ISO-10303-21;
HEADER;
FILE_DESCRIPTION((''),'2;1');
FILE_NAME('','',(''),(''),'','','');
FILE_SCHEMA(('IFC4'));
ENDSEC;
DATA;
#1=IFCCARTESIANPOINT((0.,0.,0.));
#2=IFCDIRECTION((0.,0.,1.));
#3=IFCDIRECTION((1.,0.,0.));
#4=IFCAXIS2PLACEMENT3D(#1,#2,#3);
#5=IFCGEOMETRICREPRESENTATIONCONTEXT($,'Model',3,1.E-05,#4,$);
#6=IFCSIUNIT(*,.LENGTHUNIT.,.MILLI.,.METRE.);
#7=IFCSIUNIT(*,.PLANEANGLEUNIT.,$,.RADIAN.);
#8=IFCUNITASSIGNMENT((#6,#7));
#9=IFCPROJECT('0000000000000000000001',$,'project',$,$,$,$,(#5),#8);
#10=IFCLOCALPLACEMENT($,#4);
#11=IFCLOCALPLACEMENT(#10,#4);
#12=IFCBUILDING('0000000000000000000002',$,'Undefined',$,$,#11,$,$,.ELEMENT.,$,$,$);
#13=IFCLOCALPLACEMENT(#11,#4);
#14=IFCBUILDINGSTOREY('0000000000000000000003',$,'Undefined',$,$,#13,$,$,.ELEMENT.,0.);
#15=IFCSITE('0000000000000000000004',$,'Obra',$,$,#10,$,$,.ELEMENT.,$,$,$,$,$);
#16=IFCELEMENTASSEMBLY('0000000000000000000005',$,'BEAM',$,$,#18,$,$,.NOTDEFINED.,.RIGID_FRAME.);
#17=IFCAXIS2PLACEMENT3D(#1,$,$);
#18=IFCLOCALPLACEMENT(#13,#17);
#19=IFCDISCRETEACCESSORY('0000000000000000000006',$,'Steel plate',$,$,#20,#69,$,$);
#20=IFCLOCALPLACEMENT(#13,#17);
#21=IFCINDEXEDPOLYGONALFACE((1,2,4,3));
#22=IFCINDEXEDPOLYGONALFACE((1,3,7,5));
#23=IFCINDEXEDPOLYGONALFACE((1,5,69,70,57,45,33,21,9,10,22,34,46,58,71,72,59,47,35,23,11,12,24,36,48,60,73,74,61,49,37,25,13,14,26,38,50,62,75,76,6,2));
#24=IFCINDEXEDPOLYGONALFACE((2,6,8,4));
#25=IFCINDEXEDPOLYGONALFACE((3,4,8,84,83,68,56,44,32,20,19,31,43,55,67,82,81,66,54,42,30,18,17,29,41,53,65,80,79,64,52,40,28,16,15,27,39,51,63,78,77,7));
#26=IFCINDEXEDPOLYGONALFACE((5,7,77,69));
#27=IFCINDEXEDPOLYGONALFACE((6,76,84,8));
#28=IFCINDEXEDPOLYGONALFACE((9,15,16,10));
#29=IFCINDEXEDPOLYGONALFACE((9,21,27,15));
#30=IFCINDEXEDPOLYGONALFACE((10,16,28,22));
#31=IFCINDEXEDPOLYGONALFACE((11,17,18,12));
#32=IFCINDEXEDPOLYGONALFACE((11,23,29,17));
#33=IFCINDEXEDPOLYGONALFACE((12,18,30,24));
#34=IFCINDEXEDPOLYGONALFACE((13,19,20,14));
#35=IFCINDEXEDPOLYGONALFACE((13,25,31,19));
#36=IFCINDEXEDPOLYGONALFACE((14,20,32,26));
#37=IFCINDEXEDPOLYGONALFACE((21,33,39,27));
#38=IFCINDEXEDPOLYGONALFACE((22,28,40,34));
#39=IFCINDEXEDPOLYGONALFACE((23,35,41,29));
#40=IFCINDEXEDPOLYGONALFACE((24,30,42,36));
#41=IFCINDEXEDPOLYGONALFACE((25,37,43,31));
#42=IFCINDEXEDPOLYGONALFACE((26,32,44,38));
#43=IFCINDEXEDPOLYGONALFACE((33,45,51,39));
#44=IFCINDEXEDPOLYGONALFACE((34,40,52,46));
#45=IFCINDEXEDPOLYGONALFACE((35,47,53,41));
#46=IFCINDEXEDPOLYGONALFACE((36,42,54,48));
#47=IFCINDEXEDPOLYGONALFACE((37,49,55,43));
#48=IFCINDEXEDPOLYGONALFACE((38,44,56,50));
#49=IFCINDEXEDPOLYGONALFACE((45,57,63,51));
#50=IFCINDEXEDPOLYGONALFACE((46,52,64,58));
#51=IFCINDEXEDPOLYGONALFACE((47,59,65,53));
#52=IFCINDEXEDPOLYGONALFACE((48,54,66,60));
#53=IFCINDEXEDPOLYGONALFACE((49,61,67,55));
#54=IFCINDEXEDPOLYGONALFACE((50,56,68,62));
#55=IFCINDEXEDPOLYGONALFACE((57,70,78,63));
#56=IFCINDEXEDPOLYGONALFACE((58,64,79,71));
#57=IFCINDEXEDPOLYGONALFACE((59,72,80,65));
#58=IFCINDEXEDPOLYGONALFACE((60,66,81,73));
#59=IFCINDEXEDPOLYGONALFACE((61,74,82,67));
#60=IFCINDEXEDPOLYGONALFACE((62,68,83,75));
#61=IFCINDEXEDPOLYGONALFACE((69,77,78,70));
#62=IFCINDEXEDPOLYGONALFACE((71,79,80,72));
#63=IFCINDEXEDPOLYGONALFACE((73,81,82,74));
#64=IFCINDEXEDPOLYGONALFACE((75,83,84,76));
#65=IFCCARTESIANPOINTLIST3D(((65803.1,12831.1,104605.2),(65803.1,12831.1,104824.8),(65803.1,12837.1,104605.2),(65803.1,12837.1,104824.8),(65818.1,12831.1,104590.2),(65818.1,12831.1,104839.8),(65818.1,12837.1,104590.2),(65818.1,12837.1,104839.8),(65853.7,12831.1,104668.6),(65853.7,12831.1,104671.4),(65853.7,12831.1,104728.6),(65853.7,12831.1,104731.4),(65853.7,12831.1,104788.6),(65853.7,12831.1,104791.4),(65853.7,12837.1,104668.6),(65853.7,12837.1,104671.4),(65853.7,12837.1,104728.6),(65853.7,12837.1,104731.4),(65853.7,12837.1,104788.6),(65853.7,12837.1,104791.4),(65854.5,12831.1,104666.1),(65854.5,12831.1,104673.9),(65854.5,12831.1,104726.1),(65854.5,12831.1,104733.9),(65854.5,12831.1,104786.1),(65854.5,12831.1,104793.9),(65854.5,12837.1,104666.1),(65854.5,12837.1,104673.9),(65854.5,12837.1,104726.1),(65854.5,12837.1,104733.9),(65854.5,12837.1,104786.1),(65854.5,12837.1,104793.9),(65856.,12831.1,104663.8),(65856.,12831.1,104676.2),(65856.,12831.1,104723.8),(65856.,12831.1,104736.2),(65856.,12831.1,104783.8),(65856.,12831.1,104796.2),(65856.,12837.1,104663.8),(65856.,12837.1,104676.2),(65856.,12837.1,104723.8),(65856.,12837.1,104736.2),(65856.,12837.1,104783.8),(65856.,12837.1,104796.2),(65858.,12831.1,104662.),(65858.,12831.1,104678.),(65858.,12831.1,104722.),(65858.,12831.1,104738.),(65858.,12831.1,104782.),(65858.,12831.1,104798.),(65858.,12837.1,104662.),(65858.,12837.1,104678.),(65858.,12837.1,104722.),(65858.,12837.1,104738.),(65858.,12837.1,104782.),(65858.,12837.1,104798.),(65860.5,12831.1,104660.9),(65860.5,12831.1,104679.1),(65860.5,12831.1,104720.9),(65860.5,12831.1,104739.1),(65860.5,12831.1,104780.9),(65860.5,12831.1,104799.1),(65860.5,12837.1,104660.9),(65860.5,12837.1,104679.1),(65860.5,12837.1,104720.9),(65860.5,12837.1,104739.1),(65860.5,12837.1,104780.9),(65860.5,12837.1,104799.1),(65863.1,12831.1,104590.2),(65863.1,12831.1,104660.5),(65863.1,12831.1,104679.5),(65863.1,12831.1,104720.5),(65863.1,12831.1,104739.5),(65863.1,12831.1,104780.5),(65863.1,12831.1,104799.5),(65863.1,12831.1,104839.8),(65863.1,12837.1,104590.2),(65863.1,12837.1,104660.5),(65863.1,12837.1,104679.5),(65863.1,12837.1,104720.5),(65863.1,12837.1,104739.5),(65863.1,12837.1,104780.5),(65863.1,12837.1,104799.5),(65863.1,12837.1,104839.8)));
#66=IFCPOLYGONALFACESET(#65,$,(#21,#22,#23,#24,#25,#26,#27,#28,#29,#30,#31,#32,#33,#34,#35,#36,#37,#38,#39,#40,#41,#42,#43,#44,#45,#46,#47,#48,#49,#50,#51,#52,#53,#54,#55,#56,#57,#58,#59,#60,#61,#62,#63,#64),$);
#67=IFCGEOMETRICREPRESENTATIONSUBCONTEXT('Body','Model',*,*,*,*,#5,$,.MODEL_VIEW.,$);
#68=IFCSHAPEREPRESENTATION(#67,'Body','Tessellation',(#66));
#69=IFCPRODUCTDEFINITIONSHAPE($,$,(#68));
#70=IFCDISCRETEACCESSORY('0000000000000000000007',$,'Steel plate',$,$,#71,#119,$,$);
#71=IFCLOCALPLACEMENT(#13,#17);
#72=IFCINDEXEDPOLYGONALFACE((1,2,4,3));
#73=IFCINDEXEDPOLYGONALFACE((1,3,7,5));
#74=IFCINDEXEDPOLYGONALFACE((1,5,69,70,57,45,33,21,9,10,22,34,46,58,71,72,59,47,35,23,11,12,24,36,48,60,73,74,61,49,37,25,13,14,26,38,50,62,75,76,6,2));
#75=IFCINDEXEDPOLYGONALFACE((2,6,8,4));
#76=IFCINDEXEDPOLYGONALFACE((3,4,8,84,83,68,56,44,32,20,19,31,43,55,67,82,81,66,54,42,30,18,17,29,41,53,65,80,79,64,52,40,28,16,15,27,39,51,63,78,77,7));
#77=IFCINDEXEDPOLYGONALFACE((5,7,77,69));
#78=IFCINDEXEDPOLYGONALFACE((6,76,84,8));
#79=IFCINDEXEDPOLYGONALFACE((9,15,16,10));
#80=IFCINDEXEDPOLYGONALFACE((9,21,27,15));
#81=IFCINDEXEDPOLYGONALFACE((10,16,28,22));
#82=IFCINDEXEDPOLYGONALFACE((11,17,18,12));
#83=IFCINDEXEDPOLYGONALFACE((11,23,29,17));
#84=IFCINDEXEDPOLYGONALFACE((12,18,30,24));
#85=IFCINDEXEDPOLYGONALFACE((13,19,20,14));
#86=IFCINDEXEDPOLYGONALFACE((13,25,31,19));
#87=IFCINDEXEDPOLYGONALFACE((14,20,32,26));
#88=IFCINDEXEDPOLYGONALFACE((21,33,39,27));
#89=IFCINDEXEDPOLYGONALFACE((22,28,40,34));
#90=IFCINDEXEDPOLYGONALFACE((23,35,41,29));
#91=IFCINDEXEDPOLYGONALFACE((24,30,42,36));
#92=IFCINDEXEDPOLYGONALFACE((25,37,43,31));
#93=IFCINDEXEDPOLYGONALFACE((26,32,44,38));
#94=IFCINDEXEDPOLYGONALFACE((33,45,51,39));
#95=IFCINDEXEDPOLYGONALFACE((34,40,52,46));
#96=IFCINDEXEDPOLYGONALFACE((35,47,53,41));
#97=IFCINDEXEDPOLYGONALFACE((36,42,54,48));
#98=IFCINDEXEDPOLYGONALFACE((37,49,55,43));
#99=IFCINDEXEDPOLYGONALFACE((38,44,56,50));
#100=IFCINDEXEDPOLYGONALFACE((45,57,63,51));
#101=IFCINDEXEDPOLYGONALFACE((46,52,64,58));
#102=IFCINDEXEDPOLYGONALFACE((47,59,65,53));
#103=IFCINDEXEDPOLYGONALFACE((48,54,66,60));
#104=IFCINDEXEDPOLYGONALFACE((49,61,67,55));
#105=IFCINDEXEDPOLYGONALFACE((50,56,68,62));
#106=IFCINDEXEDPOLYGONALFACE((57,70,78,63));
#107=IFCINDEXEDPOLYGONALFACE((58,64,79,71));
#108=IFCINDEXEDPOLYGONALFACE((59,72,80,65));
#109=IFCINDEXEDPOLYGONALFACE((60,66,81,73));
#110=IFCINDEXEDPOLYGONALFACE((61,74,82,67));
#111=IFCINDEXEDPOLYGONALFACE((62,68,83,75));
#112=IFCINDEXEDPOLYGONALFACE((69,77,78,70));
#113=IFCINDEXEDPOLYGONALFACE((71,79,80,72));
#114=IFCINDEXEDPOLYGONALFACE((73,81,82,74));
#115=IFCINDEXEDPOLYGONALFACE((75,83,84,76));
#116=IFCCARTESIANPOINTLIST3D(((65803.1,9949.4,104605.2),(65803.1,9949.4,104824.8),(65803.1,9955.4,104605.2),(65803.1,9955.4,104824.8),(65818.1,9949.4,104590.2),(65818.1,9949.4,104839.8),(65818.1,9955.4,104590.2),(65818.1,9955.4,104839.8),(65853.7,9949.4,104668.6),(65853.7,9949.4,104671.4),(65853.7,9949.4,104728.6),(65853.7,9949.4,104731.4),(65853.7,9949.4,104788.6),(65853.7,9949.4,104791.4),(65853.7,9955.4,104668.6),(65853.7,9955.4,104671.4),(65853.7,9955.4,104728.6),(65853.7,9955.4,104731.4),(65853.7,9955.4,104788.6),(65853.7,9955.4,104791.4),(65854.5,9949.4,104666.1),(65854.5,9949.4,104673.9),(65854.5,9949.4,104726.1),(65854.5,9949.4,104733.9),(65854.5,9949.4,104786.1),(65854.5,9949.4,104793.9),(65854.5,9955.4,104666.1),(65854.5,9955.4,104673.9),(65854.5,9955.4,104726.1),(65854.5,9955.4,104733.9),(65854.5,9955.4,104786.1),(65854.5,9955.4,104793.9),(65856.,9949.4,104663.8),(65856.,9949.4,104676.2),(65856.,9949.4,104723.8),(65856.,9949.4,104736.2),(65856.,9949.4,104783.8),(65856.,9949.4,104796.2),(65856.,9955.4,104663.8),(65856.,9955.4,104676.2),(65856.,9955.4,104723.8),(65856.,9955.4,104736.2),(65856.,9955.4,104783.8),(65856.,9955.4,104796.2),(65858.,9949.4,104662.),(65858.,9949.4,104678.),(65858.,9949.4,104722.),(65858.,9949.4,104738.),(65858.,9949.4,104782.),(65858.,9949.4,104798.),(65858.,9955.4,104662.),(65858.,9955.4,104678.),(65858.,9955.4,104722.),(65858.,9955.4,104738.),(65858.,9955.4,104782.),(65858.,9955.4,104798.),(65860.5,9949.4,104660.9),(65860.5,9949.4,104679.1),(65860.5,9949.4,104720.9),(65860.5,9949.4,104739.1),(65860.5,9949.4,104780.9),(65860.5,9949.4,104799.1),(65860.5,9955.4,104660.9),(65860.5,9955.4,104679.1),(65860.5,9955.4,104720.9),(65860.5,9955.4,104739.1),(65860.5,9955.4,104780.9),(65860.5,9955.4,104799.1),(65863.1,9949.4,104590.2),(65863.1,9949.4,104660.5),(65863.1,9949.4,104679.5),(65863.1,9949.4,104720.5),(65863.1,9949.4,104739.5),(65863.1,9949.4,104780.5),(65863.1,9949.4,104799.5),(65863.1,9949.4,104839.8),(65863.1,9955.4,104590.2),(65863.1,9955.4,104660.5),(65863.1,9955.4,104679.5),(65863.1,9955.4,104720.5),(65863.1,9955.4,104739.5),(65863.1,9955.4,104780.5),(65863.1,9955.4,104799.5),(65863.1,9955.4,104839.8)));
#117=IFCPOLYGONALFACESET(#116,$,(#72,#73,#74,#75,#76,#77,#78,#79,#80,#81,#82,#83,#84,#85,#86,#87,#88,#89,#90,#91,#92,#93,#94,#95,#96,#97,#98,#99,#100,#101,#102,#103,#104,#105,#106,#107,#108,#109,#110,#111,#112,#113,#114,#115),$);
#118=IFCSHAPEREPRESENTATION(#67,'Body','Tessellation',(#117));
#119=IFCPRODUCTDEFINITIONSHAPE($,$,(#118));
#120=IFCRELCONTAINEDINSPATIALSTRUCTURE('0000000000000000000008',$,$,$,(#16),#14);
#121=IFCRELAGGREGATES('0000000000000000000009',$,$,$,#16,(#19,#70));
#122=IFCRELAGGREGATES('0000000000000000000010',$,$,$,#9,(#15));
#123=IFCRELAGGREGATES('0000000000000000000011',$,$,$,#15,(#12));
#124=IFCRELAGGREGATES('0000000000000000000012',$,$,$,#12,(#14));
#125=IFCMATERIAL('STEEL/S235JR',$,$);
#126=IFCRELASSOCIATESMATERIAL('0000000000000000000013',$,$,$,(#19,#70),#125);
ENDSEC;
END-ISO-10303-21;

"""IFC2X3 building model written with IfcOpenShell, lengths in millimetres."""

from ifc_helpers import new_model, si_unit, frame, origin_with_axes, origin_2d_with_axis, place, context, subcontext, project, spatial, polyline, circle, outline, extrude, source, transform, mapped, material, element, aggregate, save


model = new_model("IFC2X3")

# Units and contexts
model_context = context("Model", 3, precision=1e-05, world=origin_with_axes())
body_context = subcontext(model_context, "Body", "Model", "MODEL_VIEW")
ifc_project = project(units=[si_unit("LENGTHUNIT", "METRE", prefix="MILLI"), si_unit("PLANEANGLEUNIT", "RADIAN")], contexts=[model_context])

# Site, building, storey
site_placement = place(None, origin_with_axes())
site = spatial("IfcSite", under=ifc_project, at=site_placement, Name="Obra", CompositionType="ELEMENT")
building_placement = place(site_placement, origin_with_axes())
building = spatial("IfcBuilding", under=site, at=building_placement, Name="Undefined", CompositionType="ELEMENT")
storey_placement = place(building_placement, origin_with_axes())
storey = spatial("IfcBuildingStorey", under=building, at=storey_placement, Name="Undefined", CompositionType="ELEMENT", Elevation=0.0)

# Element assembly, discrete accessories, openings
assembly_1_placement = place(storey_placement, origin_with_axes())
assembly_1 = element("IfcElementAssembly", 1, at=assembly_1_placement, inside=storey, Name="BEAM", AssemblyPlace="NOTDEFINED", PredefinedType="RIGID_FRAME")
ifc_material = material(Name="STEEL/S235JR")
discrete_accessory_1_placement = place(assembly_1_placement, frame((65863.1, 12834.1, 104590.2), z_axis=(0.0, 1.0, 0.0), x_axis=(-1.0, 0.0, 0.0)))
discrete_accessory_1 = element("IfcDiscreteAccessory", 2, at=discrete_accessory_1_placement, material=ifc_material, Name="Steel plate", context=body_context, shape_type="SweptSolid", body=[
    extrude(outline(polyline([(0.0, 0.0), (45.0, 0.0), (60.0, 15.0), (60.0, 234.6), (45.0, 249.6), (0.0, 249.6), (0.0, 0.0)])), frame((0.0, 0.0, -3.0), z_axis=(0.0, 0.0, 1.0), x_axis=(1.0, 0.0, 0.0)), (0.0, 0.0, 1.0), 6.0),
])
shared_shape_1 = source(origin_with_axes(), body_context, "Body", "SweptSolid", [
    extrude(circle(Radius=9.5, at=origin_2d_with_axis()), frame((0.0, -9.2, 0.0), z_axis=(0.0, 1.0, 0.0), x_axis=(1.0, 0.0, 0.0)), (0.0, 0.0, 1.0), 6.2),
])
opening_1_placement = place(assembly_1_placement, frame((65813.1, 12840.2, 104850.0), z_axis=(1.0, 0.0, 0.0), x_axis=(0.0, 0.0, -1.0)))
element("IfcOpeningElement", 3, at=opening_1_placement, cuts=discrete_accessory_1, ObjectType="Opening", context=body_context, shape_type="MappedRepresentation", body=[
    mapped(shared_shape_1, transform((60.0, 0.0, 50.0))),
    mapped(shared_shape_1, transform((120.0, 0.0, 50.0))),
    mapped(shared_shape_1, transform((180.0, 0.0, 50.0))),
])
discrete_accessory_2_placement = place(assembly_1_placement, frame((65863.1, 9952.4, 104590.2), z_axis=(0.0, 1.0, 0.0), x_axis=(-1.0, 0.0, 0.0)))
discrete_accessory_2 = element("IfcDiscreteAccessory", 4, at=discrete_accessory_2_placement, material=ifc_material, Name="Steel plate", context=body_context, shape_type="SweptSolid", body=[
    extrude(outline(polyline([(0.0, 0.0), (45.0, 0.0), (60.0, 15.0), (60.0, 234.6), (45.0, 249.6), (0.0, 249.6), (0.0, 0.0)])), frame((0.0, 0.0, -3.0), z_axis=(0.0, 0.0, 1.0), x_axis=(1.0, 0.0, 0.0)), (0.0, 0.0, 1.0), 6.0),
])
opening_2_placement = place(assembly_1_placement, frame((65813.1, 9958.5, 104850.0), z_axis=(1.0, 0.0, 0.0), x_axis=(0.0, 0.0, -1.0)))
element("IfcOpeningElement", 5, at=opening_2_placement, cuts=discrete_accessory_2, ObjectType="Opening", context=body_context, shape_type="MappedRepresentation", body=[
    mapped(shared_shape_1, transform((60.0, 0.0, 50.0))),
    mapped(shared_shape_1, transform((120.0, 0.0, 50.0))),
    mapped(shared_shape_1, transform((180.0, 0.0, 50.0))),
])
aggregate(assembly_1, [discrete_accessory_1, discrete_accessory_2])

save(model, "model.ifc")
